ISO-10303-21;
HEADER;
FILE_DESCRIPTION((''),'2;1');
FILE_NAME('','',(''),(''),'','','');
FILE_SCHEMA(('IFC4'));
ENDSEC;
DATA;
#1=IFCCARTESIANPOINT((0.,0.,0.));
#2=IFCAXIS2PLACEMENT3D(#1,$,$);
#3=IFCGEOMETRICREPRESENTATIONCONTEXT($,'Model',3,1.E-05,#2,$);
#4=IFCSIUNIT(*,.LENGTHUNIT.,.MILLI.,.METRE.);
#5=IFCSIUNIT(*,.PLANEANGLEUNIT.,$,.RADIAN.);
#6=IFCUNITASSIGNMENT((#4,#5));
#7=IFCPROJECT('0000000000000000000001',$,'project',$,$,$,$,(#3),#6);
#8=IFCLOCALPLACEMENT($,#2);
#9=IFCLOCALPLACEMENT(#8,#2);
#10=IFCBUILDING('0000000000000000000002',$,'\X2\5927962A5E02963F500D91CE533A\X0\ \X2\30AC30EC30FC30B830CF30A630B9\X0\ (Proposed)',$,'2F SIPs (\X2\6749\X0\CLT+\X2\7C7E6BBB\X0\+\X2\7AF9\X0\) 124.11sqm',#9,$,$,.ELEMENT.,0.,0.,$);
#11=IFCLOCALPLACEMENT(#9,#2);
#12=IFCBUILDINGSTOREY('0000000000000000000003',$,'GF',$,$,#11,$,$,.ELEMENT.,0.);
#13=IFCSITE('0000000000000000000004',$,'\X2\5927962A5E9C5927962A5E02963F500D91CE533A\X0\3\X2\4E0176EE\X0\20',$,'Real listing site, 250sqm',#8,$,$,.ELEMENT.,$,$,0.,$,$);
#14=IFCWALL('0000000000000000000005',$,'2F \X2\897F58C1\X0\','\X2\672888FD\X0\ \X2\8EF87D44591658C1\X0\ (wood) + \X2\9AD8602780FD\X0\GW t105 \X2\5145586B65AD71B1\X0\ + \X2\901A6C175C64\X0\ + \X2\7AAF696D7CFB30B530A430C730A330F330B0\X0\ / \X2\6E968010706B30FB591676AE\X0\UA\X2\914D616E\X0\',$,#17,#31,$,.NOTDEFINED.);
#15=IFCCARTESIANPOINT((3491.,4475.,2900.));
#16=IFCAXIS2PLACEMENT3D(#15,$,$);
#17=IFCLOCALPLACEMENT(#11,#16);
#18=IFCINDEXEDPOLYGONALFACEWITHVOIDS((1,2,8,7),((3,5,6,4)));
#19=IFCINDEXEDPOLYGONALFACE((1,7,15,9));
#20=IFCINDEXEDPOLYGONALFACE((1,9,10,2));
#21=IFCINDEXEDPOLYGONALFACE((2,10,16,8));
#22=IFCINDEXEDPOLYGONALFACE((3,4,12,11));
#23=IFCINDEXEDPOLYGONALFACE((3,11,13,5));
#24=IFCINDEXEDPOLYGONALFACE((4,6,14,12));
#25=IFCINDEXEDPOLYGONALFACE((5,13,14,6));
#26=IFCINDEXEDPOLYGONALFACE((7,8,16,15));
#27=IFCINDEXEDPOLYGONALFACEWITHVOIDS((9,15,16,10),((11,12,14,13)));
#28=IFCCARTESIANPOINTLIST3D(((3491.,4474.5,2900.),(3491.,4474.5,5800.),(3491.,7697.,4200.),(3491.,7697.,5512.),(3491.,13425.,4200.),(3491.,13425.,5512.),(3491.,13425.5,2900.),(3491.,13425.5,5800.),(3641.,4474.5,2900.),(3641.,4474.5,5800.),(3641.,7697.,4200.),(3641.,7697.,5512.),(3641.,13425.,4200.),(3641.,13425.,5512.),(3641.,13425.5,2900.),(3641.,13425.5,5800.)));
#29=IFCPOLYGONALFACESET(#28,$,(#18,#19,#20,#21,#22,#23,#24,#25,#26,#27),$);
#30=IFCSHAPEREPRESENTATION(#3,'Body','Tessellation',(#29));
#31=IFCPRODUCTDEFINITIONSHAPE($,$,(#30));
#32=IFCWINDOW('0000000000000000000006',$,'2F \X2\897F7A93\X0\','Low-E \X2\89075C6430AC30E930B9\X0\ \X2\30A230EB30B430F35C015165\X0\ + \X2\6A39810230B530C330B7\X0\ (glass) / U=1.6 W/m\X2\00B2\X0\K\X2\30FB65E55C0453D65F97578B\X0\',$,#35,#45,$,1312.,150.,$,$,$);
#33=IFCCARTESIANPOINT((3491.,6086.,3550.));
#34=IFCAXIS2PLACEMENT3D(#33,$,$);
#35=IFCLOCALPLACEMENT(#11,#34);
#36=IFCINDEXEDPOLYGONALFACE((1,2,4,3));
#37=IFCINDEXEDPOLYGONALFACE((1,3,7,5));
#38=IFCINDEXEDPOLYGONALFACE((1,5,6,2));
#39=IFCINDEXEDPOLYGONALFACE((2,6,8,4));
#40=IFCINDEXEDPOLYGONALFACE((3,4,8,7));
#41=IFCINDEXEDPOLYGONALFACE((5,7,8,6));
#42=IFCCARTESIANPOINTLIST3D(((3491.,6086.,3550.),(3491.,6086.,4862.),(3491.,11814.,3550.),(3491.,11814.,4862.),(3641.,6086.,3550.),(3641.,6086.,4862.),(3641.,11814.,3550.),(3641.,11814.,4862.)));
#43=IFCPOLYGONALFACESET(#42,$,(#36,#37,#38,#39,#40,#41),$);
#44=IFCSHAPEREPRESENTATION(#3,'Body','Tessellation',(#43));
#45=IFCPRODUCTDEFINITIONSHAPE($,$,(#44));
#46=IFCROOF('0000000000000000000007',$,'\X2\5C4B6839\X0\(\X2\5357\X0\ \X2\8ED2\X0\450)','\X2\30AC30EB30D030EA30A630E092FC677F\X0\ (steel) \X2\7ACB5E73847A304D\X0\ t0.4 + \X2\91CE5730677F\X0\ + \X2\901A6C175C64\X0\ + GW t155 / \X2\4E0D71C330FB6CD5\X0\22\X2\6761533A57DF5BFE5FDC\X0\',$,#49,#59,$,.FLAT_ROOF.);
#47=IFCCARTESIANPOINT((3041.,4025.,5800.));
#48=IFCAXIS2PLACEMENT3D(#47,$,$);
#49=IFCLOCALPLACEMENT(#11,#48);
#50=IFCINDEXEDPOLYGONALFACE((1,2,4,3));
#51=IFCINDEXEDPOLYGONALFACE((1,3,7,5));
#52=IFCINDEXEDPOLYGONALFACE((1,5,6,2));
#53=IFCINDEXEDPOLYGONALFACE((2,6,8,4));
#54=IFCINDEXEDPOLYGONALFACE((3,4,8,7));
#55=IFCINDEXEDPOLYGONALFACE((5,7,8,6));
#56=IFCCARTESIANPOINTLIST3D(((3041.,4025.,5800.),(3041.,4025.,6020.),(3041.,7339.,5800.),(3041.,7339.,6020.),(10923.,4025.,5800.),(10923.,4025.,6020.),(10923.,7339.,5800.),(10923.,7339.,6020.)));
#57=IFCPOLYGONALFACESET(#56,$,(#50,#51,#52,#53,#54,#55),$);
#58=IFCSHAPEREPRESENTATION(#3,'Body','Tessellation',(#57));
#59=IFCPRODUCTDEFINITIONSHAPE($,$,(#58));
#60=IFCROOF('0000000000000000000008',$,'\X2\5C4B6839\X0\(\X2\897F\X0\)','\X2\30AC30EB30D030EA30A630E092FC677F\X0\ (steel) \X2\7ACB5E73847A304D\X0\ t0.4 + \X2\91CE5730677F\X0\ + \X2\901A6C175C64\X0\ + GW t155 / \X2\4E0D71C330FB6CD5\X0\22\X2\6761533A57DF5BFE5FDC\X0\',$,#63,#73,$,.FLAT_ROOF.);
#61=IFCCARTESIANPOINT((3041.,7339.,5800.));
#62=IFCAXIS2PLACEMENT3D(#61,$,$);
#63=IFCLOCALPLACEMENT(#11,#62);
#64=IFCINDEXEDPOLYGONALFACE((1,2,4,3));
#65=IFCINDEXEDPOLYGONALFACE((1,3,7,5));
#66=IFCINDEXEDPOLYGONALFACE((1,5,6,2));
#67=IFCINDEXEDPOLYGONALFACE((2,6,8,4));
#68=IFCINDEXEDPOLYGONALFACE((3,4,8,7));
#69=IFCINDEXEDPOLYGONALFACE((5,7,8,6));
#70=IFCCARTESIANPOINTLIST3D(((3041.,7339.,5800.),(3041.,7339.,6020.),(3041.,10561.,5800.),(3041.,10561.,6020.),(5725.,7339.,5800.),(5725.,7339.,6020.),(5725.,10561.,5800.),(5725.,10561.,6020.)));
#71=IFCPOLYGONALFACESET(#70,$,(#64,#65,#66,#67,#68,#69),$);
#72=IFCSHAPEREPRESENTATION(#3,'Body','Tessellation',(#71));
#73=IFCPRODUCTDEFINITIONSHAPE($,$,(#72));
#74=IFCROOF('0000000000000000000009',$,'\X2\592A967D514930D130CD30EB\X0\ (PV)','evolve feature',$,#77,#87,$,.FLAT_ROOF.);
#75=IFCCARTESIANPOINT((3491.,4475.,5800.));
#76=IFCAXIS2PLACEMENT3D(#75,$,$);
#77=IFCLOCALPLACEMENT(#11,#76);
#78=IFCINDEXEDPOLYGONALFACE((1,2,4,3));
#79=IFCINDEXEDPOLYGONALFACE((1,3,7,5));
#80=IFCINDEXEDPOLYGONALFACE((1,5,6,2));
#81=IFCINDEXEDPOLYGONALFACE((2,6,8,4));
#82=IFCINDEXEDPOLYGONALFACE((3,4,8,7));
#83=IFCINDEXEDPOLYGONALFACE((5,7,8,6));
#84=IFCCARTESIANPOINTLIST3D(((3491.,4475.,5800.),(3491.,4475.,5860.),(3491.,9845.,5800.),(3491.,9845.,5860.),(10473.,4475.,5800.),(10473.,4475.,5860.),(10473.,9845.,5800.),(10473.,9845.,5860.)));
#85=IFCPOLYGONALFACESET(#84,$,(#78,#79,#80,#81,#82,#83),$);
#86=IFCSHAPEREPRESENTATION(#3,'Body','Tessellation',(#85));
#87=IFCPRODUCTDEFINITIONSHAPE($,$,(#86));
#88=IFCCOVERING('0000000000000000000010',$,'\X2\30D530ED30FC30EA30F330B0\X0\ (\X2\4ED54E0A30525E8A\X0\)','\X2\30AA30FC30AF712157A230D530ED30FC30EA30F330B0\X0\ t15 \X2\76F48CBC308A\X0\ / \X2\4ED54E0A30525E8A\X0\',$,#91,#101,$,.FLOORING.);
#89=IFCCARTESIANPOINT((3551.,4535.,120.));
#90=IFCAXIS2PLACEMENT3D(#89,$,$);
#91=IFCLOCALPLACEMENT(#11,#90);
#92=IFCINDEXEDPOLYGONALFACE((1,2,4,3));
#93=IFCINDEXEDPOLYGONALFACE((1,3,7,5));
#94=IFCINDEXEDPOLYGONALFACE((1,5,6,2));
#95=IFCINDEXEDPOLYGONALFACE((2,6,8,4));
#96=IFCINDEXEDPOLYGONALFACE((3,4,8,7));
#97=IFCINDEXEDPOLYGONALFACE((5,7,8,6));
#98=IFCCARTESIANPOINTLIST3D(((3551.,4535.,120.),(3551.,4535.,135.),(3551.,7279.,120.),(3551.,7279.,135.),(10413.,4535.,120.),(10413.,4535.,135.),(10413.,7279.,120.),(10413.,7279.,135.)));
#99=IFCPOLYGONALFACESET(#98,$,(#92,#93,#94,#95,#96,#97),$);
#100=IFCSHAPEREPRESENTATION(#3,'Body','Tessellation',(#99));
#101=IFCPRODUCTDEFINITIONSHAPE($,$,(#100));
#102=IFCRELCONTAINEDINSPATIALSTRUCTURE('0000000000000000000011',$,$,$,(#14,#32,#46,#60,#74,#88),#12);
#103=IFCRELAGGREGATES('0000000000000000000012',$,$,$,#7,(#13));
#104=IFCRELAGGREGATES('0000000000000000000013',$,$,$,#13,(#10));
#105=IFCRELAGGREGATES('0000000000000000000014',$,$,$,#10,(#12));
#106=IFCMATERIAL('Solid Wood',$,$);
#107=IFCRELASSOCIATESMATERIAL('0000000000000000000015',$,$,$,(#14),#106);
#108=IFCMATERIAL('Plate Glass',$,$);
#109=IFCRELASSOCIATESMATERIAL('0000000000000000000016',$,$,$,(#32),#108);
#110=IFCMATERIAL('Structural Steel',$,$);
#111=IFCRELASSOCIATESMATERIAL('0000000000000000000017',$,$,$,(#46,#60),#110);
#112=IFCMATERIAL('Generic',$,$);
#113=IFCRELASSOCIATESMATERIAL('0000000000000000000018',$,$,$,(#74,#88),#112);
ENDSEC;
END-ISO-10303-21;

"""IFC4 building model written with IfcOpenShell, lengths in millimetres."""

from ifc_helpers import new_model, si_unit, frame, frame_2d, origin, place, context, project, spatial, rectangle, extrude, material, element, fill, save


model = new_model("IFC4")

# Units and contexts
model_context = context("Model", 3, precision=1e-05, world=origin())
ifc_project = project(units=[si_unit("LENGTHUNIT", "METRE", prefix="MILLI"), si_unit("PLANEANGLEUNIT", "RADIAN")], contexts=[model_context])

# Site, building, storey
site_placement = place(None, origin())
site = spatial("IfcSite", under=ifc_project, at=site_placement, Name="大阪府大阪市阿倍野区3丁目20", ObjectType="Real listing site, 250sqm", CompositionType="ELEMENT", RefElevation=0.0)
building_placement = place(site_placement, origin())
building = spatial("IfcBuilding", under=site, at=building_placement, Name="大阪市阿倍野区 ガレージハウス (Proposed)", ObjectType="2F SIPs (杉CLT+籾殻+竹) 124.11sqm", CompositionType="ELEMENT", ElevationOfRefHeight=0.0, ElevationOfTerrain=0.0)
storey_placement = place(building_placement, origin())
storey = spatial("IfcBuildingStorey", under=building, at=storey_placement, Name="GF", CompositionType="ELEMENT", Elevation=0.0)

# Shared definitions
ifc_material_1 = material(Name="Solid Wood")
ifc_material_2 = material(Name="Generic")

# Shared definitions
ifc_material_3 = material(Name="Plate Glass")

# Wall, opening, window
wall_1_placement = place(storey_placement, frame((3491.0, 4475.0, 2900.0)))
wall_1 = element("IfcWall", 1, at=wall_1_placement, inside=storey, material=ifc_material_1, Name="2F 西壁", Description="木製 軸組外壁 (wood) + 高性能GW t105 充填断熱 + 通気層 + 窯業系サイディング / 準耐火・外皮UA配慮", PredefinedType="NOTDEFINED", context=model_context, shape_type="SweptSolid", body=[
    extrude(rectangle(XDim=150.0, YDim=8951.0, at=frame_2d((75.0, 4475.0))), frame((3491.0, 4475.0, 2900.0)), (0.0, 0.0, 1.0), 2900.0),
])
opening_1_placement = place(storey_placement, frame((3491.0, 6086.0, 3550.0)))
opening_1 = element("IfcOpeningElement", 2, at=opening_1_placement, cuts=wall_1, PredefinedType="NOTDEFINED", context=model_context, shape_type="SweptSolid", body=[
    extrude(rectangle(XDim=150.0, YDim=5728.0, at=frame_2d((75.0, 2864.0))), frame((3491.0, 6086.0, 3550.0)), (0.0, 0.0, 1.0), 1312.0),
])
window_1_placement = place(storey_placement, frame((3491.0, 6086.0, 3550.0)))
window_1 = element("IfcWindow", 3, at=window_1_placement, inside=storey, material=ifc_material_3, Name="2F 西窓", Description="Low-E 複層ガラス アルゴン封入 + 樹脂サッシ (glass) / U=1.6 W/m²K・日射取得型", OverallHeight=1312.0, OverallWidth=150.0, context=model_context, shape_type="SweptSolid", body=[
    extrude(rectangle(XDim=150.0, YDim=5728.0, at=frame_2d((75.0, 2864.0))), frame((3491.0, 6086.0, 3550.0)), (0.0, 0.0, 1.0), 1312.0),
])
fill(opening_1, window_1)

# Roofs
ifc_material_4 = material(Name="Structural Steel")
roof_1_placement = place(storey_placement, frame((3041.0, 4025.0, 5800.0)))
element("IfcRoof", 4, at=roof_1_placement, inside=storey, material=ifc_material_4, Name="屋根(南 軒450)", Description="ガルバリウム鋼板 (steel) 立平葺き t0.4 + 野地板 + 通気層 + GW t155 / 不燃・法22条区域対応", PredefinedType="FLAT_ROOF", context=model_context, shape_type="SweptSolid", body=[
    extrude(rectangle(XDim=7882.0, YDim=3314.0, at=frame_2d((3941.0, 1657.0))), frame((3041.0, 4025.0, 5800.0)), (0.0, 0.0, 1.0), 220.0),
])
roof_2_placement = place(storey_placement, frame((3041.0, 7339.0, 5800.0)))
element("IfcRoof", 5, at=roof_2_placement, inside=storey, material=ifc_material_4, Name="屋根(西)", Description="ガルバリウム鋼板 (steel) 立平葺き t0.4 + 野地板 + 通気層 + GW t155 / 不燃・法22条区域対応", PredefinedType="FLAT_ROOF", context=model_context, shape_type="SweptSolid", body=[
    extrude(rectangle(XDim=2684.0, YDim=3222.0, at=frame_2d((1342.0, 1611.0))), frame((3041.0, 7339.0, 5800.0)), (0.0, 0.0, 1.0), 220.0),
])
roof_3_placement = place(storey_placement, frame((3491.0, 4475.0, 5800.0)))
element("IfcRoof", 6, at=roof_3_placement, inside=storey, material=ifc_material_2, Name="太陽光パネル (PV)", Description="evolve feature", PredefinedType="FLAT_ROOF", context=model_context, shape_type="SweptSolid", body=[
    extrude(rectangle(XDim=6982.0, YDim=5370.0, at=frame_2d((3491.0, 2685.0))), frame((3491.0, 4475.0, 5800.0)), (0.0, 0.0, 1.0), 60.0),
])

# Covering
covering_placement = place(storey_placement, frame((3551.0, 4535.0, 120.0)))
element("IfcCovering", 7, at=covering_placement, inside=storey, material=ifc_material_2, Name="フローリング (仕上げ床)", Description="オーク無垢フローリング t15 直貼り / 仕上げ床", PredefinedType="FLOORING", context=model_context, shape_type="SweptSolid", body=[
    extrude(rectangle(XDim=6862.0, YDim=2744.0, at=frame_2d((3431.0, 1372.0))), frame((3551.0, 4535.0, 120.0)), (0.0, 0.0, 1.0), 15.0),
])

save(model, "model.ifc")
